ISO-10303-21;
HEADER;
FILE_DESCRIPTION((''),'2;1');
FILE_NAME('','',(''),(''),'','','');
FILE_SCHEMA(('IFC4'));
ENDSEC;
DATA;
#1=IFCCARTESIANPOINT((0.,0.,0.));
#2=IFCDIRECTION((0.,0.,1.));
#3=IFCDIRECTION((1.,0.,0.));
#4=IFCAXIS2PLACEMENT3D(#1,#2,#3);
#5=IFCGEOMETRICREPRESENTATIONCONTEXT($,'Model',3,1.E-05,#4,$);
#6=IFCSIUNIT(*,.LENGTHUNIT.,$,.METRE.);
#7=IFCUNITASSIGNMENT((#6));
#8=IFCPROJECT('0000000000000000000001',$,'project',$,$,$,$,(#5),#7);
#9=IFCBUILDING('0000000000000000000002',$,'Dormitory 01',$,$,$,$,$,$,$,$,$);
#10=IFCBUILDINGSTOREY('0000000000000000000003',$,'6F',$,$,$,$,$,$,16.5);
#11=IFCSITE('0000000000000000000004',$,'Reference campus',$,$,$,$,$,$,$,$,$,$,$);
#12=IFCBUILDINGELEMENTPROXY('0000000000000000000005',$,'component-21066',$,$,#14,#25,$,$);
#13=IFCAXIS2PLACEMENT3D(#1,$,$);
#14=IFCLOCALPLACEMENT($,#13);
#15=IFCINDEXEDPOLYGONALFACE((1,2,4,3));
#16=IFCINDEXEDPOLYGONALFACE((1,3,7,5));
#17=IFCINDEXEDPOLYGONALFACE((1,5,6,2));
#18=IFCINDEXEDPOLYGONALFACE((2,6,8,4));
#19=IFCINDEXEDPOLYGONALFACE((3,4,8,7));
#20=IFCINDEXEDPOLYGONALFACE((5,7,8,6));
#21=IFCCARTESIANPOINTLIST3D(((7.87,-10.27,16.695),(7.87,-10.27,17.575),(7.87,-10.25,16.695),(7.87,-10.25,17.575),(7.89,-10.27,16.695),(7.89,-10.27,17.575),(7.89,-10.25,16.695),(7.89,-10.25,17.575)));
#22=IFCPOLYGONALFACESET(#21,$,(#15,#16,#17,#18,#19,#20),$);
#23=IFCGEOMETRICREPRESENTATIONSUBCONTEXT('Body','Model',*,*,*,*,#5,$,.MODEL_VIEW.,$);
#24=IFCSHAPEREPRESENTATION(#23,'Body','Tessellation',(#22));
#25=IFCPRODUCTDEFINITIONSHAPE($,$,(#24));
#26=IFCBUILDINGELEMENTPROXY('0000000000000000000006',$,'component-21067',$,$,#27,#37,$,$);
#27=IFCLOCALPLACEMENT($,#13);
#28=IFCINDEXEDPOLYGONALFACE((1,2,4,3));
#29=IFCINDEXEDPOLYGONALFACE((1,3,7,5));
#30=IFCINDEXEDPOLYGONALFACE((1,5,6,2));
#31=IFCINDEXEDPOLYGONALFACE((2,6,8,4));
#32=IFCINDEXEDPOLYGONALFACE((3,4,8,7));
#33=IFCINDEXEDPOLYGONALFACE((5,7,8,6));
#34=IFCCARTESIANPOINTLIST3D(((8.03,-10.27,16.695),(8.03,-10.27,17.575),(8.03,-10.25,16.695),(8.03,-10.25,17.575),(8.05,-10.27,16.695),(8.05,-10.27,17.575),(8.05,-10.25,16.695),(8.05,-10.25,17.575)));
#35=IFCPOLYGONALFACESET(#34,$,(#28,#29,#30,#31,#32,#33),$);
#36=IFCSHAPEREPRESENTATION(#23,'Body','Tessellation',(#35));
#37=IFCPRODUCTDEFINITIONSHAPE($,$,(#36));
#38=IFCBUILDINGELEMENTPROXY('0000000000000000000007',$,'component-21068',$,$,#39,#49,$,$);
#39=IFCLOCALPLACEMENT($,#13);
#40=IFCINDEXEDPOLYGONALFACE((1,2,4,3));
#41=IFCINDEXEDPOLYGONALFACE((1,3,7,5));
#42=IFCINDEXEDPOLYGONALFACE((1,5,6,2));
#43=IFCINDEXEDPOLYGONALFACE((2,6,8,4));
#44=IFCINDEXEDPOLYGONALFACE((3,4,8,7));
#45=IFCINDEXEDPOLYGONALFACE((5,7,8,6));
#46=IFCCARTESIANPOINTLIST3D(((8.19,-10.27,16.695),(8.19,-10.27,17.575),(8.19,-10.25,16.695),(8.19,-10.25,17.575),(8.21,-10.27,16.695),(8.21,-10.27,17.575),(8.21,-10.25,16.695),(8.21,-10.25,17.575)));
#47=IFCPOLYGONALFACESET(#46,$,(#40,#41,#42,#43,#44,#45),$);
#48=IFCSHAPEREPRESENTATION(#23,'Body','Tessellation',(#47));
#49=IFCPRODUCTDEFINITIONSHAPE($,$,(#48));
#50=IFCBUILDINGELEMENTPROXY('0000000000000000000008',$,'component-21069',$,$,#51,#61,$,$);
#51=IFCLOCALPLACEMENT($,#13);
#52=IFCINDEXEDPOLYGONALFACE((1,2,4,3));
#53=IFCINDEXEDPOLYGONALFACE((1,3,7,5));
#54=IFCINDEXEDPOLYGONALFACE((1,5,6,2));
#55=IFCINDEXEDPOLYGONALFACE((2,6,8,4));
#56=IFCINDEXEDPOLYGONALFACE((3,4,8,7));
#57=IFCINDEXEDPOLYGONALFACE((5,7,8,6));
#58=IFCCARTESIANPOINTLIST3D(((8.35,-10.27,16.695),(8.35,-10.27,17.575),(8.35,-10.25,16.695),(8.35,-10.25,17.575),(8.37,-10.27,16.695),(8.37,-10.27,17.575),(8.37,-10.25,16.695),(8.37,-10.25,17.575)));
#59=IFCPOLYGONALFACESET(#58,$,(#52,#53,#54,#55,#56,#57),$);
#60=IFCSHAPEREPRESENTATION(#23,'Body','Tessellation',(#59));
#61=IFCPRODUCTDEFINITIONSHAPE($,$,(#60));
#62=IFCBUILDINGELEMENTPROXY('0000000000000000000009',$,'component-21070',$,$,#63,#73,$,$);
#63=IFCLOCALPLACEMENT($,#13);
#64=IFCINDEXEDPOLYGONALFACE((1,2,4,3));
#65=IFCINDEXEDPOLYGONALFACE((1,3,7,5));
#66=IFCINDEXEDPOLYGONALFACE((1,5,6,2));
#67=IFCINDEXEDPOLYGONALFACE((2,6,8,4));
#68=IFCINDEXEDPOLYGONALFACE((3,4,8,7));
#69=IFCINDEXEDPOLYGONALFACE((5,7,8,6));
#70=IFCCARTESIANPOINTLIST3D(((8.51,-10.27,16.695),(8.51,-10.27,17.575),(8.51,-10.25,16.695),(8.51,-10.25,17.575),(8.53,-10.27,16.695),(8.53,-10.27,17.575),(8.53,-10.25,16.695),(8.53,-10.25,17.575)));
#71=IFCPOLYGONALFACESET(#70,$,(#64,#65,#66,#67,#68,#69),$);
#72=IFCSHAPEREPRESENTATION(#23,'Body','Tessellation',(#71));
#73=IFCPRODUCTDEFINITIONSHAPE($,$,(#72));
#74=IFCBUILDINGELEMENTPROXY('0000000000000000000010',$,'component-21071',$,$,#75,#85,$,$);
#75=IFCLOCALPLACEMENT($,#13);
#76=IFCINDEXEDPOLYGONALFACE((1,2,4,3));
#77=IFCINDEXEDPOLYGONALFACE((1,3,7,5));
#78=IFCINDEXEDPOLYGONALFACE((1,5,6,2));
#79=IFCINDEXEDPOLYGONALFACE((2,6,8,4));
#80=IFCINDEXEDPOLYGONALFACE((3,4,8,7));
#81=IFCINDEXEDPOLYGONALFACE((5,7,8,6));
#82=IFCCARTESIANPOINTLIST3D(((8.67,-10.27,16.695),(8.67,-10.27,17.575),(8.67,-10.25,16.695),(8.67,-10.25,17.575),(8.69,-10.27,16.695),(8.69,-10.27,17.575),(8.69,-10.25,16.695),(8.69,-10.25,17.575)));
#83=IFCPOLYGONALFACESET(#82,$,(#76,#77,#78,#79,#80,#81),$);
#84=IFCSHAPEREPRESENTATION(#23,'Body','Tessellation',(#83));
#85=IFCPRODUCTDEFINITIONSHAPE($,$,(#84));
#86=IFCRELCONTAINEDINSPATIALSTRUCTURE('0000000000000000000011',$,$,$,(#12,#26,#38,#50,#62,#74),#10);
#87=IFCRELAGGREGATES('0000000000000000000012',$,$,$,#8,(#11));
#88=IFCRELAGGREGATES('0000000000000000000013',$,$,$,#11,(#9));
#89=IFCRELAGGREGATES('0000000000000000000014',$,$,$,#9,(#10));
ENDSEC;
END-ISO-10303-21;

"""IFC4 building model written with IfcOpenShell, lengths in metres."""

from ifc_helpers import new_model, si_unit, frame, origin, origin_with_axes, origin_2d, place, context, subcontext, project, spatial, rectangle, extrude, element, save


model = new_model("IFC4")

# Units and contexts
model_context = context("Model", 3, precision=1e-05, world=origin_with_axes())
body_context = subcontext(model_context, "Body", "Model", "MODEL_VIEW")
ifc_project = project(units=[si_unit("LENGTHUNIT", "METRE")], contexts=[model_context])

# Site, building, storey
site = spatial("IfcSite", under=ifc_project, Name="Reference campus")
building = spatial("IfcBuilding", under=site, Name="Dormitory 01")
storey = spatial("IfcBuildingStorey", under=building, Name="6F", Elevation=16.5)

# Building element proxies
for number, where, z_axis, x_axis, name in (
    (1, (7.88, -10.26, 16.695), (0.0, 0.0, 1.0), (1.0, 0.0, 0.0), "component-21066"),
    (2, (8.04, -10.26, 16.695), (0.0, 0.0, 1.0), (1.0, 0.0, 0.0), "component-21067"),
    (3, (8.2, -10.26, 16.695), (0.0, 0.0, 1.0), (1.0, 0.0, 0.0), "component-21068"),
    (4, (8.36, -10.26, 16.695), (0.0, 0.0, 1.0), (1.0, 0.0, 0.0), "component-21069"),
    (5, (8.52, -10.26, 16.695), (0.0, 0.0, 1.0), (1.0, 0.0, 0.0), "component-21070"),
    (6, (8.68, -10.26, 16.695), (0.0, 0.0, 1.0), (1.0, 0.0, 0.0), "component-21071"),
):
    element("IfcBuildingElementProxy", number, at=place(None, frame(where, z_axis=z_axis, x_axis=x_axis)), inside=storey, Name=name, context=body_context, shape_type="SweptSolid", body=[
        extrude(rectangle(XDim=0.02, YDim=0.02, at=origin_2d()), origin(), (0.0, 0.0, 1.0), 0.88),
    ])

save(model, "model.ifc")
